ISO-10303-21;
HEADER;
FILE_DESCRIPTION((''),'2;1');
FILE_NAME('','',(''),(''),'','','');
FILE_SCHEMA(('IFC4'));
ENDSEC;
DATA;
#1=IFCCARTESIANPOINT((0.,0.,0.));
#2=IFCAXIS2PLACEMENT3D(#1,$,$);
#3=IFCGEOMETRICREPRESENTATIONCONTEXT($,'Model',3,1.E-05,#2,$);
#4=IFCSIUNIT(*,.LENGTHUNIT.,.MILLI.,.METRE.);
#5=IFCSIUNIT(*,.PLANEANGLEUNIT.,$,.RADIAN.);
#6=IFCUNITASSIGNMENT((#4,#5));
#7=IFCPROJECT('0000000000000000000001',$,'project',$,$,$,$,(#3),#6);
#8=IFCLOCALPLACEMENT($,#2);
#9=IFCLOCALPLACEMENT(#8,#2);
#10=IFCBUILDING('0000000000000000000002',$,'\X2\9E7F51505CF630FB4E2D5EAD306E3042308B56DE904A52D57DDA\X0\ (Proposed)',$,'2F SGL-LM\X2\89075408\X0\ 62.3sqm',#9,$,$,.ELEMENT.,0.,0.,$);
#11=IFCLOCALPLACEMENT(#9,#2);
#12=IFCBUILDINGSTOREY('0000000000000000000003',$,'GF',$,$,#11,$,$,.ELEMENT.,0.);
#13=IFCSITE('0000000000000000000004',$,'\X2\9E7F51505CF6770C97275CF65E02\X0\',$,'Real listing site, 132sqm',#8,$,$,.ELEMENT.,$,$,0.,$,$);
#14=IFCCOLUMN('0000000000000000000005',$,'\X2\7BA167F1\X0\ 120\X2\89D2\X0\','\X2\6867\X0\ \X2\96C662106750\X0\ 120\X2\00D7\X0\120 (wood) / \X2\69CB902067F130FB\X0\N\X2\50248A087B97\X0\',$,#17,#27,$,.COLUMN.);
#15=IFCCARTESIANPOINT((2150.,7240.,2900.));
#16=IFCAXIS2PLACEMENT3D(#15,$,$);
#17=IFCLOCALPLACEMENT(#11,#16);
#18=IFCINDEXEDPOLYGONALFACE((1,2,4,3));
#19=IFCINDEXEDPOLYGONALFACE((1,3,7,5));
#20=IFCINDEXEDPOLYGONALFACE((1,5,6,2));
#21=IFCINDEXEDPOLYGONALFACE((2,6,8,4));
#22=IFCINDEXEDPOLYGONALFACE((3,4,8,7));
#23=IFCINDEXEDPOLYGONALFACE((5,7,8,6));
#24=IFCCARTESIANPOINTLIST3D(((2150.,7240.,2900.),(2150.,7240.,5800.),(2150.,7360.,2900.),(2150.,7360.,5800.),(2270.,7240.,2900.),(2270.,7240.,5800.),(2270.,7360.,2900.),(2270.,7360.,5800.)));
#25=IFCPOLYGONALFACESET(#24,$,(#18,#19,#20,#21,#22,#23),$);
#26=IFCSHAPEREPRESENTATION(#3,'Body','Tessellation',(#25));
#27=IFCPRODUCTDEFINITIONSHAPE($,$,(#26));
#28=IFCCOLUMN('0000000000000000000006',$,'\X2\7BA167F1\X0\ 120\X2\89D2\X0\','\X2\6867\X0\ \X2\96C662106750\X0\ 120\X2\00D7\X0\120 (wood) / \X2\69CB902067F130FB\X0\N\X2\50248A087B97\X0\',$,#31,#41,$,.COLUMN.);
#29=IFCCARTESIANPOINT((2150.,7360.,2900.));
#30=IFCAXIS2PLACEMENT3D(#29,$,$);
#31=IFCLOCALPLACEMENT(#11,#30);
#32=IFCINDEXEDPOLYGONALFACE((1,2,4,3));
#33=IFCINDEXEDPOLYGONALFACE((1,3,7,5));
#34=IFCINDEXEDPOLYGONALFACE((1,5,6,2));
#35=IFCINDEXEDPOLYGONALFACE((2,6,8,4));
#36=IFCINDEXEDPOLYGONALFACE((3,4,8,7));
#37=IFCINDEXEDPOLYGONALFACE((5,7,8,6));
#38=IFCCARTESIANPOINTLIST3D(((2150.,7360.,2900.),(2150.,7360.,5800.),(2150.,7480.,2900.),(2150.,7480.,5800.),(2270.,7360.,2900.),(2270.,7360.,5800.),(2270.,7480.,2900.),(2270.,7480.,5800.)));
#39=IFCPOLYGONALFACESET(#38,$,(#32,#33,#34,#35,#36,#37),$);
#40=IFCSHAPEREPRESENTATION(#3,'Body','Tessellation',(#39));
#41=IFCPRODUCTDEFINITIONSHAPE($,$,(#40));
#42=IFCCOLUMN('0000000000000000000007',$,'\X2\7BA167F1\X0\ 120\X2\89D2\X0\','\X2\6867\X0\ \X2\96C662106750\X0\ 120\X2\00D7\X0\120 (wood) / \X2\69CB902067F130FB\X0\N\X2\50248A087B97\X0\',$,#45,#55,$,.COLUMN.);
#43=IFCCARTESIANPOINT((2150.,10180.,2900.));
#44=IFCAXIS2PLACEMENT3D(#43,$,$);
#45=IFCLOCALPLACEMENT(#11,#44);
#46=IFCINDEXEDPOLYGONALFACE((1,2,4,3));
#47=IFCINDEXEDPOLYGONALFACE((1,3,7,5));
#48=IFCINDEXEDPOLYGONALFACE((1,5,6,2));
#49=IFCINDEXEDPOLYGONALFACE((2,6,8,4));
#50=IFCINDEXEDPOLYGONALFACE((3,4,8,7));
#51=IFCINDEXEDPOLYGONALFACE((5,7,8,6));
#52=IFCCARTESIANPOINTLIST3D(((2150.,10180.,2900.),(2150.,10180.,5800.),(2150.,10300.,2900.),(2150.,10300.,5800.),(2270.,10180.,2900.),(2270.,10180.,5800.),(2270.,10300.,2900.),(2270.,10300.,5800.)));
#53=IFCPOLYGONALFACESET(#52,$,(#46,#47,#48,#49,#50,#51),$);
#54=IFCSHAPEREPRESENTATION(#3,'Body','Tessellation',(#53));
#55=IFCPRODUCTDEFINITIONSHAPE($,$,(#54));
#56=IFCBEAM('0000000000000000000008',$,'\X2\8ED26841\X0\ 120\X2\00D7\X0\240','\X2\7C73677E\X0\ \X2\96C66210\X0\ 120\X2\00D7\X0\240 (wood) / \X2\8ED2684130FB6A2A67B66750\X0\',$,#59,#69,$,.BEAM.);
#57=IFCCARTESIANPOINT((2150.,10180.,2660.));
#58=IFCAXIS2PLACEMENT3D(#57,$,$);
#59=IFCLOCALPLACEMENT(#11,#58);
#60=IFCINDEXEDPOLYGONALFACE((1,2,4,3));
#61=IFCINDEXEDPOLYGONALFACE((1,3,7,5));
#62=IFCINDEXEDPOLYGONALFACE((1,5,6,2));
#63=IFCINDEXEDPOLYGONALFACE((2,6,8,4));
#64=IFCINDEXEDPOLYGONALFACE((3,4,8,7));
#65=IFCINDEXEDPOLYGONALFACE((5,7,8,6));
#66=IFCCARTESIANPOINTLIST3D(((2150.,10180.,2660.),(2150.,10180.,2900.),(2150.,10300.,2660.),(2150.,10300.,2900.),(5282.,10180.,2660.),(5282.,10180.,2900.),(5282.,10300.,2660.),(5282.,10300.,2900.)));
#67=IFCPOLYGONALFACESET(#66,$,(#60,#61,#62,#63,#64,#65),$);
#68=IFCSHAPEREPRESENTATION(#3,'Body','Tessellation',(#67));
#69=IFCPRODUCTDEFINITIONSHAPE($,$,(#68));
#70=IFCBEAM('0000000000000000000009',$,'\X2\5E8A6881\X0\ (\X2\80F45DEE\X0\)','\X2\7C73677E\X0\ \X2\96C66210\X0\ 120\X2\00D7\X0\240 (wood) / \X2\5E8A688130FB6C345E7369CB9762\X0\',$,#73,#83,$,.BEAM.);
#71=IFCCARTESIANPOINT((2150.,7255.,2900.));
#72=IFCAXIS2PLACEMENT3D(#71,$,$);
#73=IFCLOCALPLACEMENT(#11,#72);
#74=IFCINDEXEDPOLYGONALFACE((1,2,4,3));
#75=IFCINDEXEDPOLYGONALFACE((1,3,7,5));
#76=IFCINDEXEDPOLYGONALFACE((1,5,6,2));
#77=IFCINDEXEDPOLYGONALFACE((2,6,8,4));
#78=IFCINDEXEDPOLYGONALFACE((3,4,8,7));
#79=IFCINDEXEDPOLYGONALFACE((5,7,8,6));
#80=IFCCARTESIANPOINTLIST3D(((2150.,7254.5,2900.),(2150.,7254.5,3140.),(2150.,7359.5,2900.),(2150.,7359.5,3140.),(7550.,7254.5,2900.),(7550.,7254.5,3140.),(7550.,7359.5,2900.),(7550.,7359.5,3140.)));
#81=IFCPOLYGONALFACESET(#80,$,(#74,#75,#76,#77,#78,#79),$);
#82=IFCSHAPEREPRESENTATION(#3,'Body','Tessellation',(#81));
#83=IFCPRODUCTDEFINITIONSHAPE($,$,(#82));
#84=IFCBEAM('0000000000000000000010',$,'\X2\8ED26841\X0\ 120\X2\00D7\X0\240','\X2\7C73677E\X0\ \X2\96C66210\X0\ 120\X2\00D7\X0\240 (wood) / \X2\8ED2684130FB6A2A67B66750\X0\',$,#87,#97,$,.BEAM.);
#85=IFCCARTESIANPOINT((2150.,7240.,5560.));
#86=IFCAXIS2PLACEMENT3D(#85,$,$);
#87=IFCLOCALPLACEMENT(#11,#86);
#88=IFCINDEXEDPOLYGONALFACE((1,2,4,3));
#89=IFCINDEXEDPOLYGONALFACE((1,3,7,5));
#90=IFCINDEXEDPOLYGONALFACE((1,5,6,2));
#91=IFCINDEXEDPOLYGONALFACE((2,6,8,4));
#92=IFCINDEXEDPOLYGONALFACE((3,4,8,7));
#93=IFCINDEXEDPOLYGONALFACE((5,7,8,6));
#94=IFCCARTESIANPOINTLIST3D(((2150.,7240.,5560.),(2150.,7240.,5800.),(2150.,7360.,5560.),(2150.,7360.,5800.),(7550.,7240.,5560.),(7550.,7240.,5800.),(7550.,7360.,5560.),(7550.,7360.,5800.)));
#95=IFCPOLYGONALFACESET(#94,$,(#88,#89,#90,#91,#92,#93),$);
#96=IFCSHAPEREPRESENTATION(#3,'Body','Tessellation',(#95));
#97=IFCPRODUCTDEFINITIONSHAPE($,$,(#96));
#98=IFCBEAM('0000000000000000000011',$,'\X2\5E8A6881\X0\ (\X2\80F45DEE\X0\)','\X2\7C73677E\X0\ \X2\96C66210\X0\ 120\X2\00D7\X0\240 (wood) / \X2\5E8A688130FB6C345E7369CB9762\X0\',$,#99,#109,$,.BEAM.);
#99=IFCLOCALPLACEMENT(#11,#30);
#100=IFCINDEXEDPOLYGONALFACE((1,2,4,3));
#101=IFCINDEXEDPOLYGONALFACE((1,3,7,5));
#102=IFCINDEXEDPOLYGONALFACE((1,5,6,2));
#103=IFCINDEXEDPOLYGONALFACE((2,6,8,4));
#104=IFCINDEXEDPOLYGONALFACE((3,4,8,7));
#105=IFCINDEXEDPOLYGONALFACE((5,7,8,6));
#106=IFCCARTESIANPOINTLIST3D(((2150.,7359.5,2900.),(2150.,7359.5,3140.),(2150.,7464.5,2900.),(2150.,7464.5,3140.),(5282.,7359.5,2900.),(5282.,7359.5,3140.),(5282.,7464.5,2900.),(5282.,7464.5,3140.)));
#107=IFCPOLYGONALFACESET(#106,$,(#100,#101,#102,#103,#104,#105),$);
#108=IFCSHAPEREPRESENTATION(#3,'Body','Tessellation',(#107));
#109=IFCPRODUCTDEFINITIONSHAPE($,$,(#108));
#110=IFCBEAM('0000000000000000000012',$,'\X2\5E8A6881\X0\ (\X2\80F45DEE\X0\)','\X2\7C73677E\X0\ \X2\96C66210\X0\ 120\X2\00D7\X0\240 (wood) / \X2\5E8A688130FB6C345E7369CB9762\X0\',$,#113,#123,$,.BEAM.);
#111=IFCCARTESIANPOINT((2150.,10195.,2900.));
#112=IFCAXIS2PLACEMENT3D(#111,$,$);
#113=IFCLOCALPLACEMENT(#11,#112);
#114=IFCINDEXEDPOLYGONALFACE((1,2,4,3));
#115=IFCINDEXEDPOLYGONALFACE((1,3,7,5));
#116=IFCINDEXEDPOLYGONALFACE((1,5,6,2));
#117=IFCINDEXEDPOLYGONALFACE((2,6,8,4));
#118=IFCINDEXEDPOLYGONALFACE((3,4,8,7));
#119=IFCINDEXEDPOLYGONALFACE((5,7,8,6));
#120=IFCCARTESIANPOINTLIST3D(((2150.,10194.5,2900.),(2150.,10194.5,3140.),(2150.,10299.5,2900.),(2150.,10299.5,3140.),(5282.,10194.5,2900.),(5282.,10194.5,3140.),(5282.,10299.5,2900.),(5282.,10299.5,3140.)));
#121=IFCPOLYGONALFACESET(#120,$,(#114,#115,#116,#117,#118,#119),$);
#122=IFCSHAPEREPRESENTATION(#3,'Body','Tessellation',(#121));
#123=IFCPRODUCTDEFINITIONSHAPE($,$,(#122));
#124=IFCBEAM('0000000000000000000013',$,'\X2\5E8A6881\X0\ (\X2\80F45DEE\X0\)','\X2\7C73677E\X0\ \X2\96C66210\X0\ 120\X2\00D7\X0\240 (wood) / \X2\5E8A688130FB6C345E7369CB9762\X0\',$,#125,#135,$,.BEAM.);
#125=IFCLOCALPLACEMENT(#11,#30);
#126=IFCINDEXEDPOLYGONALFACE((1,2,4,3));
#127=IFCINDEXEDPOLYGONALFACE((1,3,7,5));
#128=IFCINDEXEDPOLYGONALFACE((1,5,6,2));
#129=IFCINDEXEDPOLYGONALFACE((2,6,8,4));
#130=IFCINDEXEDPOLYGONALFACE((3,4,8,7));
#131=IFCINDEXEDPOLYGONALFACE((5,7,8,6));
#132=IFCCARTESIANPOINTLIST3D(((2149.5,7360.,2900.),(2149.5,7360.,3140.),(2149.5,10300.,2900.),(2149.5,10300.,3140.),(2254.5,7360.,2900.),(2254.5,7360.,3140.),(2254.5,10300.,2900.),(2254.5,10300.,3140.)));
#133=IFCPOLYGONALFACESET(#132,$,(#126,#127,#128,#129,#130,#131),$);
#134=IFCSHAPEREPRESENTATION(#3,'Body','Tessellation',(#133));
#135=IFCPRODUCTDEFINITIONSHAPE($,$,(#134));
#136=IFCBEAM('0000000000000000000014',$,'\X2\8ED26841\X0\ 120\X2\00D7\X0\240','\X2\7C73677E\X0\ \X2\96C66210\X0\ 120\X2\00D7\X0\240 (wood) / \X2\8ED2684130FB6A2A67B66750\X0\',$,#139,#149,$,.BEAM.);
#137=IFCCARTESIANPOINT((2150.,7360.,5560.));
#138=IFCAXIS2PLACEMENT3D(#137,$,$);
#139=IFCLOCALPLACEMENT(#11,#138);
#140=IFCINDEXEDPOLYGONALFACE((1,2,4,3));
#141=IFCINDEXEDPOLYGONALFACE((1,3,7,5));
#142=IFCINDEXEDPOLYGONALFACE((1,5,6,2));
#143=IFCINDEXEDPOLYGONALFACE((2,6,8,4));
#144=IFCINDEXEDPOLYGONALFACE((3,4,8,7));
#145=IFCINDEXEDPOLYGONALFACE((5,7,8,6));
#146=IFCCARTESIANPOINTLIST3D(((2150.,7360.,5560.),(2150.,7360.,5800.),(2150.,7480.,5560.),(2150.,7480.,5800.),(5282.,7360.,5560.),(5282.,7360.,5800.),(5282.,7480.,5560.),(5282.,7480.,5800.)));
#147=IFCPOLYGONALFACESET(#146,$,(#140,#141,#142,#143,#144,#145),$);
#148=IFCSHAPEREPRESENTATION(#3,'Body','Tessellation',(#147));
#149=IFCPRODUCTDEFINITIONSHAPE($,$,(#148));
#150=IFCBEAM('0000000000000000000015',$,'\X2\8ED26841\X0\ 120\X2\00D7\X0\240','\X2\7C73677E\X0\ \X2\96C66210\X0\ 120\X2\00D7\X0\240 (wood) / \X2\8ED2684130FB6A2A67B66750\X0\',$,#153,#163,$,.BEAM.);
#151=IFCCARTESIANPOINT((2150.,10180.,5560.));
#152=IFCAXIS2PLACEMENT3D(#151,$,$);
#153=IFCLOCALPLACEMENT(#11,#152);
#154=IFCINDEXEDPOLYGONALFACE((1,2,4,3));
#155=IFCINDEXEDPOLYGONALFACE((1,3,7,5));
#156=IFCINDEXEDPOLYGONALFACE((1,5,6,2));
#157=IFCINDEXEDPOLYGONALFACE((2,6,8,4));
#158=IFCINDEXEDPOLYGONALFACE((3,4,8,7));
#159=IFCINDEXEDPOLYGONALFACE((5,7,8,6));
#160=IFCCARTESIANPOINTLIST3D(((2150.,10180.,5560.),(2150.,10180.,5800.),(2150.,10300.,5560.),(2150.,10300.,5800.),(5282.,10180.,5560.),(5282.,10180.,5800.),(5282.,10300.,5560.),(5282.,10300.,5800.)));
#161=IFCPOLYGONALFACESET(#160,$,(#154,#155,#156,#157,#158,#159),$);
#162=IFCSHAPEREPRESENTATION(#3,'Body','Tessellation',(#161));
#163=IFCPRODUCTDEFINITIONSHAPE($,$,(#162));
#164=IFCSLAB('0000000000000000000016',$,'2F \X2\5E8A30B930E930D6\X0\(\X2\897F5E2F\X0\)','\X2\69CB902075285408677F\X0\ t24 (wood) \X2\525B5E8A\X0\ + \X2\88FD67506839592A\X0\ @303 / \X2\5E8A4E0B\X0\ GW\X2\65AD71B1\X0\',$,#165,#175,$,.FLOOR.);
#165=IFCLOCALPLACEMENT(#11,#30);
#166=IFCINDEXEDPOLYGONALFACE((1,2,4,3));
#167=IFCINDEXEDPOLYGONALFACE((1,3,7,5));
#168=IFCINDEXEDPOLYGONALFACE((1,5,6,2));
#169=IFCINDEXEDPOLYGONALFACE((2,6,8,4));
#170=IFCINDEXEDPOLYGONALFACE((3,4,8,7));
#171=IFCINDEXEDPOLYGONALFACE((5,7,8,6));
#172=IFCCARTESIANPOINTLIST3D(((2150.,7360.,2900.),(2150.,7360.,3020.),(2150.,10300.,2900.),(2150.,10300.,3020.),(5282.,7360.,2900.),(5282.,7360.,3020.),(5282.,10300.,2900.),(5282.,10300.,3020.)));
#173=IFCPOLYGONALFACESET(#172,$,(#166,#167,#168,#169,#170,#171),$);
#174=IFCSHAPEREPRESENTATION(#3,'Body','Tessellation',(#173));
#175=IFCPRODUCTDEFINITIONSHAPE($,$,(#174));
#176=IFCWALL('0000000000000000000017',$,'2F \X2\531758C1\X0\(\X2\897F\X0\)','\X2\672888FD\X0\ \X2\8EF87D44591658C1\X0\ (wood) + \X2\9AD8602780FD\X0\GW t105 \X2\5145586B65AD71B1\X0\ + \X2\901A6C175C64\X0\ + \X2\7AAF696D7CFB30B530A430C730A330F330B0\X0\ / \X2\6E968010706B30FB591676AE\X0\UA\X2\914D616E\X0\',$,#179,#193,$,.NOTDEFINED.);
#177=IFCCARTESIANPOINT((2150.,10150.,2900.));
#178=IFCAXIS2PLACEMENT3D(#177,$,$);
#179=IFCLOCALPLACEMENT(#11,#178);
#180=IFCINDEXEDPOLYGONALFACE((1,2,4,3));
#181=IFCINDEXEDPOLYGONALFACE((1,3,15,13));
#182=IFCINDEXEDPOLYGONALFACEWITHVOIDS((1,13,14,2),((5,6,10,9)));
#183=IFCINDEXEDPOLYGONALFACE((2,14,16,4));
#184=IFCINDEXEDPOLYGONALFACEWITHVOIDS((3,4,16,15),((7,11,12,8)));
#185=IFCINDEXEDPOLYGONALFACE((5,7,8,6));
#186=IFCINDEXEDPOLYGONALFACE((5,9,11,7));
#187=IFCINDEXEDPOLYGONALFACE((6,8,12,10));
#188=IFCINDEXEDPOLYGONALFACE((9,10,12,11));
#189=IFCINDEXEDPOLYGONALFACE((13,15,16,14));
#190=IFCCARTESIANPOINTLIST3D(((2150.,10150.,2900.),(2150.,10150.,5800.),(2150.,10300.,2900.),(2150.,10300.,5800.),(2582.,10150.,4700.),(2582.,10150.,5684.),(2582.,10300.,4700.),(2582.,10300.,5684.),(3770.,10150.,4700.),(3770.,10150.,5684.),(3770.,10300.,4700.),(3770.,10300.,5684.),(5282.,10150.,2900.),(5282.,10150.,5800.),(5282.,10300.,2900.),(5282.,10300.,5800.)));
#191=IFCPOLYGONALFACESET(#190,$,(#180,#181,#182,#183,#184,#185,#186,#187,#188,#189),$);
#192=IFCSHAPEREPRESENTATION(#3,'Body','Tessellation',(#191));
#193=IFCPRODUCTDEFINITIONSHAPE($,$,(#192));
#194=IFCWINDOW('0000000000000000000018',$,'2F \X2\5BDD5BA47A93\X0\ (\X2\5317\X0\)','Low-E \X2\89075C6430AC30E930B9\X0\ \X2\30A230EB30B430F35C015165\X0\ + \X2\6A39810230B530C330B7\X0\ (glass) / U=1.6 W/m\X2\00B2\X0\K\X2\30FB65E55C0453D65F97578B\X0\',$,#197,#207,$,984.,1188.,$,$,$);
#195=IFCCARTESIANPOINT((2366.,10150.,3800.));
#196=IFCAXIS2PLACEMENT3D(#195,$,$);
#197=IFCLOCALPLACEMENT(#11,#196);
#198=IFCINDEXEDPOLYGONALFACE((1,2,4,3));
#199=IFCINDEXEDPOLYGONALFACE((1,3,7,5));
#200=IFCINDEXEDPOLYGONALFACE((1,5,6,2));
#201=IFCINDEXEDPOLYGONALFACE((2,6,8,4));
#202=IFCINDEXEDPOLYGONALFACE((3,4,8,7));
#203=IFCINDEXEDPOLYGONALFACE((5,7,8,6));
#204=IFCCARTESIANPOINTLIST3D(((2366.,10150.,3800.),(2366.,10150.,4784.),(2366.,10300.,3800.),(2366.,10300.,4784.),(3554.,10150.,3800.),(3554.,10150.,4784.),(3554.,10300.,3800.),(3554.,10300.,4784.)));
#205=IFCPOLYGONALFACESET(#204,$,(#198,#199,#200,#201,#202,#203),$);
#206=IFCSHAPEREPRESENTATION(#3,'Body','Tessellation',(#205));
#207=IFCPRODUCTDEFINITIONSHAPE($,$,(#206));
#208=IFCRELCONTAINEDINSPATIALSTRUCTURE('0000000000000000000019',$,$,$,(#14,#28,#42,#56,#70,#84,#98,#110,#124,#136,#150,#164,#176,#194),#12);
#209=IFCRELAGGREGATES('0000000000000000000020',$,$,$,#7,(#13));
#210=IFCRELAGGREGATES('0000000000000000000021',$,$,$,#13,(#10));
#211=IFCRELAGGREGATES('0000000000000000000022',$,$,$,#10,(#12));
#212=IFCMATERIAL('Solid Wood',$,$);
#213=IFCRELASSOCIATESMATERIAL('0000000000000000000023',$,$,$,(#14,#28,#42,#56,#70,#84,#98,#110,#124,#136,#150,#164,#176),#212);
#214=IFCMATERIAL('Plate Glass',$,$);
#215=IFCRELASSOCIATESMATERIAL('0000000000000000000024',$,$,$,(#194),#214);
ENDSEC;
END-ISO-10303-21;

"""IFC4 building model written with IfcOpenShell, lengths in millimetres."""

from ifc_helpers import new_model, si_unit, frame, frame_2d, origin, place, context, project, spatial, rectangle, extrude, material, element, fill, save


model = new_model("IFC4")

# Units and contexts
model_context = context("Model", 3, precision=1e-05, world=origin())
ifc_project = project(units=[si_unit("LENGTHUNIT", "METRE", prefix="MILLI"), si_unit("PLANEANGLEUNIT", "RADIAN")], contexts=[model_context])

# Site, building, storey
site_placement = place(None, origin())
site = spatial("IfcSite", under=ifc_project, at=site_placement, Name="鹿児島県霧島市", ObjectType="Real listing site, 132sqm", CompositionType="ELEMENT", RefElevation=0.0)
building_placement = place(site_placement, origin())
building = spatial("IfcBuilding", under=site, at=building_placement, Name="鹿児島・中庭のある回遊動線 (Proposed)", ObjectType="2F SGL-LM複合 62.3sqm", CompositionType="ELEMENT", ElevationOfRefHeight=0.0, ElevationOfTerrain=0.0)
storey_placement = place(building_placement, origin())
storey = spatial("IfcBuildingStorey", under=building, at=storey_placement, Name="GF", CompositionType="ELEMENT", Elevation=0.0)

# Columns
ifc_material_1 = material(Name="Solid Wood")
column_1_placement = place(storey_placement, frame((2150.0, 7240.0, 2900.0)))
element("IfcColumn", 1, at=column_1_placement, inside=storey, material=ifc_material_1, Name="管柱 120角", Description="桧 集成材 120×120 (wood) / 構造柱・N値計算", PredefinedType="COLUMN", context=model_context, shape_type="SweptSolid", body=[
    extrude(rectangle(XDim=120.0, YDim=120.0, at=frame_2d((60.0, 60.0))), frame((2150.0, 7240.0, 2900.0)), (0.0, 0.0, 1.0), 2900.0),
])
column_2_placement = place(storey_placement, frame((2150.0, 7360.0, 2900.0)))
element("IfcColumn", 2, at=column_2_placement, inside=storey, material=ifc_material_1, Name="管柱 120角", Description="桧 集成材 120×120 (wood) / 構造柱・N値計算", PredefinedType="COLUMN", context=model_context, shape_type="SweptSolid", body=[
    extrude(rectangle(XDim=120.0, YDim=120.0, at=frame_2d((60.0, 60.0))), frame((2150.0, 7360.0, 2900.0)), (0.0, 0.0, 1.0), 2900.0),
])
column_3_placement = place(storey_placement, frame((2150.0, 10180.0, 2900.0)))
element("IfcColumn", 3, at=column_3_placement, inside=storey, material=ifc_material_1, Name="管柱 120角", Description="桧 集成材 120×120 (wood) / 構造柱・N値計算", PredefinedType="COLUMN", context=model_context, shape_type="SweptSolid", body=[
    extrude(rectangle(XDim=120.0, YDim=120.0, at=frame_2d((60.0, 60.0))), frame((2150.0, 10180.0, 2900.0)), (0.0, 0.0, 1.0), 2900.0),
])

# Beams
beam_1_placement = place(storey_placement, frame((2150.0, 10180.0, 2660.0)))
element("IfcBeam", 4, at=beam_1_placement, inside=storey, material=ifc_material_1, Name="軒桁 120×240", Description="米松 集成 120×240 (wood) / 軒桁・横架材", PredefinedType="BEAM", context=model_context, shape_type="SweptSolid", body=[
    extrude(rectangle(XDim=3132.0, YDim=120.0, at=frame_2d((1566.0, 60.0))), frame((2150.0, 10180.0, 2660.0)), (0.0, 0.0, 1.0), 240.0),
])
beam_2_placement = place(storey_placement, frame((2150.0, 7255.0, 2900.0)))
element("IfcBeam", 5, at=beam_2_placement, inside=storey, material=ifc_material_1, Name="床梁 (胴差)", Description="米松 集成 120×240 (wood) / 床梁・水平構面", PredefinedType="BEAM", context=model_context, shape_type="SweptSolid", body=[
    extrude(rectangle(XDim=5400.0, YDim=105.0, at=frame_2d((2700.0, 52.0))), frame((2150.0, 7255.0, 2900.0)), (0.0, 0.0, 1.0), 240.0),
])
beam_3_placement = place(storey_placement, frame((2150.0, 7240.0, 5560.0)))
element("IfcBeam", 6, at=beam_3_placement, inside=storey, material=ifc_material_1, Name="軒桁 120×240", Description="米松 集成 120×240 (wood) / 軒桁・横架材", PredefinedType="BEAM", context=model_context, shape_type="SweptSolid", body=[
    extrude(rectangle(XDim=5400.0, YDim=120.0, at=frame_2d((2700.0, 60.0))), frame((2150.0, 7240.0, 5560.0)), (0.0, 0.0, 1.0), 240.0),
])
beam_4_placement = place(storey_placement, frame((2150.0, 7360.0, 2900.0)))
element("IfcBeam", 7, at=beam_4_placement, inside=storey, material=ifc_material_1, Name="床梁 (胴差)", Description="米松 集成 120×240 (wood) / 床梁・水平構面", PredefinedType="BEAM", context=model_context, shape_type="SweptSolid", body=[
    extrude(rectangle(XDim=3132.0, YDim=105.0, at=frame_2d((1566.0, 52.0))), frame((2150.0, 7360.0, 2900.0)), (0.0, 0.0, 1.0), 240.0),
])
beam_5_placement = place(storey_placement, frame((2150.0, 10195.0, 2900.0)))
element("IfcBeam", 8, at=beam_5_placement, inside=storey, material=ifc_material_1, Name="床梁 (胴差)", Description="米松 集成 120×240 (wood) / 床梁・水平構面", PredefinedType="BEAM", context=model_context, shape_type="SweptSolid", body=[
    extrude(rectangle(XDim=3132.0, YDim=105.0, at=frame_2d((1566.0, 52.0))), frame((2150.0, 10195.0, 2900.0)), (0.0, 0.0, 1.0), 240.0),
])
beam_6_placement = place(storey_placement, frame((2150.0, 7360.0, 2900.0)))
element("IfcBeam", 9, at=beam_6_placement, inside=storey, material=ifc_material_1, Name="床梁 (胴差)", Description="米松 集成 120×240 (wood) / 床梁・水平構面", PredefinedType="BEAM", context=model_context, shape_type="SweptSolid", body=[
    extrude(rectangle(XDim=105.0, YDim=2940.0, at=frame_2d((52.0, 1470.0))), frame((2150.0, 7360.0, 2900.0)), (0.0, 0.0, 1.0), 240.0),
])
beam_7_placement = place(storey_placement, frame((2150.0, 7360.0, 5560.0)))
element("IfcBeam", 10, at=beam_7_placement, inside=storey, material=ifc_material_1, Name="軒桁 120×240", Description="米松 集成 120×240 (wood) / 軒桁・横架材", PredefinedType="BEAM", context=model_context, shape_type="SweptSolid", body=[
    extrude(rectangle(XDim=3132.0, YDim=120.0, at=frame_2d((1566.0, 60.0))), frame((2150.0, 7360.0, 5560.0)), (0.0, 0.0, 1.0), 240.0),
])
beam_8_placement = place(storey_placement, frame((2150.0, 10180.0, 5560.0)))
element("IfcBeam", 11, at=beam_8_placement, inside=storey, material=ifc_material_1, Name="軒桁 120×240", Description="米松 集成 120×240 (wood) / 軒桁・横架材", PredefinedType="BEAM", context=model_context, shape_type="SweptSolid", body=[
    extrude(rectangle(XDim=3132.0, YDim=120.0, at=frame_2d((1566.0, 60.0))), frame((2150.0, 10180.0, 5560.0)), (0.0, 0.0, 1.0), 240.0),
])

# Slab
slab_placement = place(storey_placement, frame((2150.0, 7360.0, 2900.0)))
element("IfcSlab", 12, at=slab_placement, inside=storey, material=ifc_material_1, Name="2F 床スラブ(西帯)", Description="構造用合板 t24 (wood) 剛床 + 製材根太 @303 / 床下 GW断熱", PredefinedType="FLOOR", context=model_context, shape_type="SweptSolid", body=[
    extrude(rectangle(XDim=3132.0, YDim=2940.0, at=frame_2d((1566.0, 1470.0))), frame((2150.0, 7360.0, 2900.0)), (0.0, 0.0, 1.0), 120.0),
])

# Wall, opening, window
wall_1_placement = place(storey_placement, frame((2150.0, 10150.0, 2900.0)))
wall_1 = element("IfcWall", 13, at=wall_1_placement, inside=storey, material=ifc_material_1, Name="2F 北壁(西)", Description="木製 軸組外壁 (wood) + 高性能GW t105 充填断熱 + 通気層 + 窯業系サイディング / 準耐火・外皮UA配慮", PredefinedType="NOTDEFINED", context=model_context, shape_type="SweptSolid", body=[
    extrude(rectangle(XDim=3132.0, YDim=150.0, at=frame_2d((1566.0, 75.0))), frame((2150.0, 10150.0, 2900.0)), (0.0, 0.0, 1.0), 2900.0),
])
opening_placement = place(storey_placement, frame((2366.0, 10150.0, 3800.0)))
opening = element("IfcOpeningElement", 14, at=opening_placement, cuts=wall_1, PredefinedType="NOTDEFINED", context=model_context, shape_type="SweptSolid", body=[
    extrude(rectangle(XDim=1188.0, YDim=150.0, at=frame_2d((594.0, 75.0))), frame((2366.0, 10150.0, 3800.0)), (0.0, 0.0, 1.0), 984.0),
])
ifc_material_2 = material(Name="Plate Glass")
window_placement = place(storey_placement, frame((2366.0, 10150.0, 3800.0)))
window = element("IfcWindow", 15, at=window_placement, inside=storey, material=ifc_material_2, Name="2F 寝室窓 (北)", Description="Low-E 複層ガラス アルゴン封入 + 樹脂サッシ (glass) / U=1.6 W/m²K・日射取得型", OverallHeight=984.0, OverallWidth=1188.0, context=model_context, shape_type="SweptSolid", body=[
    extrude(rectangle(XDim=1188.0, YDim=150.0, at=frame_2d((594.0, 75.0))), frame((2366.0, 10150.0, 3800.0)), (0.0, 0.0, 1.0), 984.0),
])
fill(opening, window)

save(model, "model.ifc")
